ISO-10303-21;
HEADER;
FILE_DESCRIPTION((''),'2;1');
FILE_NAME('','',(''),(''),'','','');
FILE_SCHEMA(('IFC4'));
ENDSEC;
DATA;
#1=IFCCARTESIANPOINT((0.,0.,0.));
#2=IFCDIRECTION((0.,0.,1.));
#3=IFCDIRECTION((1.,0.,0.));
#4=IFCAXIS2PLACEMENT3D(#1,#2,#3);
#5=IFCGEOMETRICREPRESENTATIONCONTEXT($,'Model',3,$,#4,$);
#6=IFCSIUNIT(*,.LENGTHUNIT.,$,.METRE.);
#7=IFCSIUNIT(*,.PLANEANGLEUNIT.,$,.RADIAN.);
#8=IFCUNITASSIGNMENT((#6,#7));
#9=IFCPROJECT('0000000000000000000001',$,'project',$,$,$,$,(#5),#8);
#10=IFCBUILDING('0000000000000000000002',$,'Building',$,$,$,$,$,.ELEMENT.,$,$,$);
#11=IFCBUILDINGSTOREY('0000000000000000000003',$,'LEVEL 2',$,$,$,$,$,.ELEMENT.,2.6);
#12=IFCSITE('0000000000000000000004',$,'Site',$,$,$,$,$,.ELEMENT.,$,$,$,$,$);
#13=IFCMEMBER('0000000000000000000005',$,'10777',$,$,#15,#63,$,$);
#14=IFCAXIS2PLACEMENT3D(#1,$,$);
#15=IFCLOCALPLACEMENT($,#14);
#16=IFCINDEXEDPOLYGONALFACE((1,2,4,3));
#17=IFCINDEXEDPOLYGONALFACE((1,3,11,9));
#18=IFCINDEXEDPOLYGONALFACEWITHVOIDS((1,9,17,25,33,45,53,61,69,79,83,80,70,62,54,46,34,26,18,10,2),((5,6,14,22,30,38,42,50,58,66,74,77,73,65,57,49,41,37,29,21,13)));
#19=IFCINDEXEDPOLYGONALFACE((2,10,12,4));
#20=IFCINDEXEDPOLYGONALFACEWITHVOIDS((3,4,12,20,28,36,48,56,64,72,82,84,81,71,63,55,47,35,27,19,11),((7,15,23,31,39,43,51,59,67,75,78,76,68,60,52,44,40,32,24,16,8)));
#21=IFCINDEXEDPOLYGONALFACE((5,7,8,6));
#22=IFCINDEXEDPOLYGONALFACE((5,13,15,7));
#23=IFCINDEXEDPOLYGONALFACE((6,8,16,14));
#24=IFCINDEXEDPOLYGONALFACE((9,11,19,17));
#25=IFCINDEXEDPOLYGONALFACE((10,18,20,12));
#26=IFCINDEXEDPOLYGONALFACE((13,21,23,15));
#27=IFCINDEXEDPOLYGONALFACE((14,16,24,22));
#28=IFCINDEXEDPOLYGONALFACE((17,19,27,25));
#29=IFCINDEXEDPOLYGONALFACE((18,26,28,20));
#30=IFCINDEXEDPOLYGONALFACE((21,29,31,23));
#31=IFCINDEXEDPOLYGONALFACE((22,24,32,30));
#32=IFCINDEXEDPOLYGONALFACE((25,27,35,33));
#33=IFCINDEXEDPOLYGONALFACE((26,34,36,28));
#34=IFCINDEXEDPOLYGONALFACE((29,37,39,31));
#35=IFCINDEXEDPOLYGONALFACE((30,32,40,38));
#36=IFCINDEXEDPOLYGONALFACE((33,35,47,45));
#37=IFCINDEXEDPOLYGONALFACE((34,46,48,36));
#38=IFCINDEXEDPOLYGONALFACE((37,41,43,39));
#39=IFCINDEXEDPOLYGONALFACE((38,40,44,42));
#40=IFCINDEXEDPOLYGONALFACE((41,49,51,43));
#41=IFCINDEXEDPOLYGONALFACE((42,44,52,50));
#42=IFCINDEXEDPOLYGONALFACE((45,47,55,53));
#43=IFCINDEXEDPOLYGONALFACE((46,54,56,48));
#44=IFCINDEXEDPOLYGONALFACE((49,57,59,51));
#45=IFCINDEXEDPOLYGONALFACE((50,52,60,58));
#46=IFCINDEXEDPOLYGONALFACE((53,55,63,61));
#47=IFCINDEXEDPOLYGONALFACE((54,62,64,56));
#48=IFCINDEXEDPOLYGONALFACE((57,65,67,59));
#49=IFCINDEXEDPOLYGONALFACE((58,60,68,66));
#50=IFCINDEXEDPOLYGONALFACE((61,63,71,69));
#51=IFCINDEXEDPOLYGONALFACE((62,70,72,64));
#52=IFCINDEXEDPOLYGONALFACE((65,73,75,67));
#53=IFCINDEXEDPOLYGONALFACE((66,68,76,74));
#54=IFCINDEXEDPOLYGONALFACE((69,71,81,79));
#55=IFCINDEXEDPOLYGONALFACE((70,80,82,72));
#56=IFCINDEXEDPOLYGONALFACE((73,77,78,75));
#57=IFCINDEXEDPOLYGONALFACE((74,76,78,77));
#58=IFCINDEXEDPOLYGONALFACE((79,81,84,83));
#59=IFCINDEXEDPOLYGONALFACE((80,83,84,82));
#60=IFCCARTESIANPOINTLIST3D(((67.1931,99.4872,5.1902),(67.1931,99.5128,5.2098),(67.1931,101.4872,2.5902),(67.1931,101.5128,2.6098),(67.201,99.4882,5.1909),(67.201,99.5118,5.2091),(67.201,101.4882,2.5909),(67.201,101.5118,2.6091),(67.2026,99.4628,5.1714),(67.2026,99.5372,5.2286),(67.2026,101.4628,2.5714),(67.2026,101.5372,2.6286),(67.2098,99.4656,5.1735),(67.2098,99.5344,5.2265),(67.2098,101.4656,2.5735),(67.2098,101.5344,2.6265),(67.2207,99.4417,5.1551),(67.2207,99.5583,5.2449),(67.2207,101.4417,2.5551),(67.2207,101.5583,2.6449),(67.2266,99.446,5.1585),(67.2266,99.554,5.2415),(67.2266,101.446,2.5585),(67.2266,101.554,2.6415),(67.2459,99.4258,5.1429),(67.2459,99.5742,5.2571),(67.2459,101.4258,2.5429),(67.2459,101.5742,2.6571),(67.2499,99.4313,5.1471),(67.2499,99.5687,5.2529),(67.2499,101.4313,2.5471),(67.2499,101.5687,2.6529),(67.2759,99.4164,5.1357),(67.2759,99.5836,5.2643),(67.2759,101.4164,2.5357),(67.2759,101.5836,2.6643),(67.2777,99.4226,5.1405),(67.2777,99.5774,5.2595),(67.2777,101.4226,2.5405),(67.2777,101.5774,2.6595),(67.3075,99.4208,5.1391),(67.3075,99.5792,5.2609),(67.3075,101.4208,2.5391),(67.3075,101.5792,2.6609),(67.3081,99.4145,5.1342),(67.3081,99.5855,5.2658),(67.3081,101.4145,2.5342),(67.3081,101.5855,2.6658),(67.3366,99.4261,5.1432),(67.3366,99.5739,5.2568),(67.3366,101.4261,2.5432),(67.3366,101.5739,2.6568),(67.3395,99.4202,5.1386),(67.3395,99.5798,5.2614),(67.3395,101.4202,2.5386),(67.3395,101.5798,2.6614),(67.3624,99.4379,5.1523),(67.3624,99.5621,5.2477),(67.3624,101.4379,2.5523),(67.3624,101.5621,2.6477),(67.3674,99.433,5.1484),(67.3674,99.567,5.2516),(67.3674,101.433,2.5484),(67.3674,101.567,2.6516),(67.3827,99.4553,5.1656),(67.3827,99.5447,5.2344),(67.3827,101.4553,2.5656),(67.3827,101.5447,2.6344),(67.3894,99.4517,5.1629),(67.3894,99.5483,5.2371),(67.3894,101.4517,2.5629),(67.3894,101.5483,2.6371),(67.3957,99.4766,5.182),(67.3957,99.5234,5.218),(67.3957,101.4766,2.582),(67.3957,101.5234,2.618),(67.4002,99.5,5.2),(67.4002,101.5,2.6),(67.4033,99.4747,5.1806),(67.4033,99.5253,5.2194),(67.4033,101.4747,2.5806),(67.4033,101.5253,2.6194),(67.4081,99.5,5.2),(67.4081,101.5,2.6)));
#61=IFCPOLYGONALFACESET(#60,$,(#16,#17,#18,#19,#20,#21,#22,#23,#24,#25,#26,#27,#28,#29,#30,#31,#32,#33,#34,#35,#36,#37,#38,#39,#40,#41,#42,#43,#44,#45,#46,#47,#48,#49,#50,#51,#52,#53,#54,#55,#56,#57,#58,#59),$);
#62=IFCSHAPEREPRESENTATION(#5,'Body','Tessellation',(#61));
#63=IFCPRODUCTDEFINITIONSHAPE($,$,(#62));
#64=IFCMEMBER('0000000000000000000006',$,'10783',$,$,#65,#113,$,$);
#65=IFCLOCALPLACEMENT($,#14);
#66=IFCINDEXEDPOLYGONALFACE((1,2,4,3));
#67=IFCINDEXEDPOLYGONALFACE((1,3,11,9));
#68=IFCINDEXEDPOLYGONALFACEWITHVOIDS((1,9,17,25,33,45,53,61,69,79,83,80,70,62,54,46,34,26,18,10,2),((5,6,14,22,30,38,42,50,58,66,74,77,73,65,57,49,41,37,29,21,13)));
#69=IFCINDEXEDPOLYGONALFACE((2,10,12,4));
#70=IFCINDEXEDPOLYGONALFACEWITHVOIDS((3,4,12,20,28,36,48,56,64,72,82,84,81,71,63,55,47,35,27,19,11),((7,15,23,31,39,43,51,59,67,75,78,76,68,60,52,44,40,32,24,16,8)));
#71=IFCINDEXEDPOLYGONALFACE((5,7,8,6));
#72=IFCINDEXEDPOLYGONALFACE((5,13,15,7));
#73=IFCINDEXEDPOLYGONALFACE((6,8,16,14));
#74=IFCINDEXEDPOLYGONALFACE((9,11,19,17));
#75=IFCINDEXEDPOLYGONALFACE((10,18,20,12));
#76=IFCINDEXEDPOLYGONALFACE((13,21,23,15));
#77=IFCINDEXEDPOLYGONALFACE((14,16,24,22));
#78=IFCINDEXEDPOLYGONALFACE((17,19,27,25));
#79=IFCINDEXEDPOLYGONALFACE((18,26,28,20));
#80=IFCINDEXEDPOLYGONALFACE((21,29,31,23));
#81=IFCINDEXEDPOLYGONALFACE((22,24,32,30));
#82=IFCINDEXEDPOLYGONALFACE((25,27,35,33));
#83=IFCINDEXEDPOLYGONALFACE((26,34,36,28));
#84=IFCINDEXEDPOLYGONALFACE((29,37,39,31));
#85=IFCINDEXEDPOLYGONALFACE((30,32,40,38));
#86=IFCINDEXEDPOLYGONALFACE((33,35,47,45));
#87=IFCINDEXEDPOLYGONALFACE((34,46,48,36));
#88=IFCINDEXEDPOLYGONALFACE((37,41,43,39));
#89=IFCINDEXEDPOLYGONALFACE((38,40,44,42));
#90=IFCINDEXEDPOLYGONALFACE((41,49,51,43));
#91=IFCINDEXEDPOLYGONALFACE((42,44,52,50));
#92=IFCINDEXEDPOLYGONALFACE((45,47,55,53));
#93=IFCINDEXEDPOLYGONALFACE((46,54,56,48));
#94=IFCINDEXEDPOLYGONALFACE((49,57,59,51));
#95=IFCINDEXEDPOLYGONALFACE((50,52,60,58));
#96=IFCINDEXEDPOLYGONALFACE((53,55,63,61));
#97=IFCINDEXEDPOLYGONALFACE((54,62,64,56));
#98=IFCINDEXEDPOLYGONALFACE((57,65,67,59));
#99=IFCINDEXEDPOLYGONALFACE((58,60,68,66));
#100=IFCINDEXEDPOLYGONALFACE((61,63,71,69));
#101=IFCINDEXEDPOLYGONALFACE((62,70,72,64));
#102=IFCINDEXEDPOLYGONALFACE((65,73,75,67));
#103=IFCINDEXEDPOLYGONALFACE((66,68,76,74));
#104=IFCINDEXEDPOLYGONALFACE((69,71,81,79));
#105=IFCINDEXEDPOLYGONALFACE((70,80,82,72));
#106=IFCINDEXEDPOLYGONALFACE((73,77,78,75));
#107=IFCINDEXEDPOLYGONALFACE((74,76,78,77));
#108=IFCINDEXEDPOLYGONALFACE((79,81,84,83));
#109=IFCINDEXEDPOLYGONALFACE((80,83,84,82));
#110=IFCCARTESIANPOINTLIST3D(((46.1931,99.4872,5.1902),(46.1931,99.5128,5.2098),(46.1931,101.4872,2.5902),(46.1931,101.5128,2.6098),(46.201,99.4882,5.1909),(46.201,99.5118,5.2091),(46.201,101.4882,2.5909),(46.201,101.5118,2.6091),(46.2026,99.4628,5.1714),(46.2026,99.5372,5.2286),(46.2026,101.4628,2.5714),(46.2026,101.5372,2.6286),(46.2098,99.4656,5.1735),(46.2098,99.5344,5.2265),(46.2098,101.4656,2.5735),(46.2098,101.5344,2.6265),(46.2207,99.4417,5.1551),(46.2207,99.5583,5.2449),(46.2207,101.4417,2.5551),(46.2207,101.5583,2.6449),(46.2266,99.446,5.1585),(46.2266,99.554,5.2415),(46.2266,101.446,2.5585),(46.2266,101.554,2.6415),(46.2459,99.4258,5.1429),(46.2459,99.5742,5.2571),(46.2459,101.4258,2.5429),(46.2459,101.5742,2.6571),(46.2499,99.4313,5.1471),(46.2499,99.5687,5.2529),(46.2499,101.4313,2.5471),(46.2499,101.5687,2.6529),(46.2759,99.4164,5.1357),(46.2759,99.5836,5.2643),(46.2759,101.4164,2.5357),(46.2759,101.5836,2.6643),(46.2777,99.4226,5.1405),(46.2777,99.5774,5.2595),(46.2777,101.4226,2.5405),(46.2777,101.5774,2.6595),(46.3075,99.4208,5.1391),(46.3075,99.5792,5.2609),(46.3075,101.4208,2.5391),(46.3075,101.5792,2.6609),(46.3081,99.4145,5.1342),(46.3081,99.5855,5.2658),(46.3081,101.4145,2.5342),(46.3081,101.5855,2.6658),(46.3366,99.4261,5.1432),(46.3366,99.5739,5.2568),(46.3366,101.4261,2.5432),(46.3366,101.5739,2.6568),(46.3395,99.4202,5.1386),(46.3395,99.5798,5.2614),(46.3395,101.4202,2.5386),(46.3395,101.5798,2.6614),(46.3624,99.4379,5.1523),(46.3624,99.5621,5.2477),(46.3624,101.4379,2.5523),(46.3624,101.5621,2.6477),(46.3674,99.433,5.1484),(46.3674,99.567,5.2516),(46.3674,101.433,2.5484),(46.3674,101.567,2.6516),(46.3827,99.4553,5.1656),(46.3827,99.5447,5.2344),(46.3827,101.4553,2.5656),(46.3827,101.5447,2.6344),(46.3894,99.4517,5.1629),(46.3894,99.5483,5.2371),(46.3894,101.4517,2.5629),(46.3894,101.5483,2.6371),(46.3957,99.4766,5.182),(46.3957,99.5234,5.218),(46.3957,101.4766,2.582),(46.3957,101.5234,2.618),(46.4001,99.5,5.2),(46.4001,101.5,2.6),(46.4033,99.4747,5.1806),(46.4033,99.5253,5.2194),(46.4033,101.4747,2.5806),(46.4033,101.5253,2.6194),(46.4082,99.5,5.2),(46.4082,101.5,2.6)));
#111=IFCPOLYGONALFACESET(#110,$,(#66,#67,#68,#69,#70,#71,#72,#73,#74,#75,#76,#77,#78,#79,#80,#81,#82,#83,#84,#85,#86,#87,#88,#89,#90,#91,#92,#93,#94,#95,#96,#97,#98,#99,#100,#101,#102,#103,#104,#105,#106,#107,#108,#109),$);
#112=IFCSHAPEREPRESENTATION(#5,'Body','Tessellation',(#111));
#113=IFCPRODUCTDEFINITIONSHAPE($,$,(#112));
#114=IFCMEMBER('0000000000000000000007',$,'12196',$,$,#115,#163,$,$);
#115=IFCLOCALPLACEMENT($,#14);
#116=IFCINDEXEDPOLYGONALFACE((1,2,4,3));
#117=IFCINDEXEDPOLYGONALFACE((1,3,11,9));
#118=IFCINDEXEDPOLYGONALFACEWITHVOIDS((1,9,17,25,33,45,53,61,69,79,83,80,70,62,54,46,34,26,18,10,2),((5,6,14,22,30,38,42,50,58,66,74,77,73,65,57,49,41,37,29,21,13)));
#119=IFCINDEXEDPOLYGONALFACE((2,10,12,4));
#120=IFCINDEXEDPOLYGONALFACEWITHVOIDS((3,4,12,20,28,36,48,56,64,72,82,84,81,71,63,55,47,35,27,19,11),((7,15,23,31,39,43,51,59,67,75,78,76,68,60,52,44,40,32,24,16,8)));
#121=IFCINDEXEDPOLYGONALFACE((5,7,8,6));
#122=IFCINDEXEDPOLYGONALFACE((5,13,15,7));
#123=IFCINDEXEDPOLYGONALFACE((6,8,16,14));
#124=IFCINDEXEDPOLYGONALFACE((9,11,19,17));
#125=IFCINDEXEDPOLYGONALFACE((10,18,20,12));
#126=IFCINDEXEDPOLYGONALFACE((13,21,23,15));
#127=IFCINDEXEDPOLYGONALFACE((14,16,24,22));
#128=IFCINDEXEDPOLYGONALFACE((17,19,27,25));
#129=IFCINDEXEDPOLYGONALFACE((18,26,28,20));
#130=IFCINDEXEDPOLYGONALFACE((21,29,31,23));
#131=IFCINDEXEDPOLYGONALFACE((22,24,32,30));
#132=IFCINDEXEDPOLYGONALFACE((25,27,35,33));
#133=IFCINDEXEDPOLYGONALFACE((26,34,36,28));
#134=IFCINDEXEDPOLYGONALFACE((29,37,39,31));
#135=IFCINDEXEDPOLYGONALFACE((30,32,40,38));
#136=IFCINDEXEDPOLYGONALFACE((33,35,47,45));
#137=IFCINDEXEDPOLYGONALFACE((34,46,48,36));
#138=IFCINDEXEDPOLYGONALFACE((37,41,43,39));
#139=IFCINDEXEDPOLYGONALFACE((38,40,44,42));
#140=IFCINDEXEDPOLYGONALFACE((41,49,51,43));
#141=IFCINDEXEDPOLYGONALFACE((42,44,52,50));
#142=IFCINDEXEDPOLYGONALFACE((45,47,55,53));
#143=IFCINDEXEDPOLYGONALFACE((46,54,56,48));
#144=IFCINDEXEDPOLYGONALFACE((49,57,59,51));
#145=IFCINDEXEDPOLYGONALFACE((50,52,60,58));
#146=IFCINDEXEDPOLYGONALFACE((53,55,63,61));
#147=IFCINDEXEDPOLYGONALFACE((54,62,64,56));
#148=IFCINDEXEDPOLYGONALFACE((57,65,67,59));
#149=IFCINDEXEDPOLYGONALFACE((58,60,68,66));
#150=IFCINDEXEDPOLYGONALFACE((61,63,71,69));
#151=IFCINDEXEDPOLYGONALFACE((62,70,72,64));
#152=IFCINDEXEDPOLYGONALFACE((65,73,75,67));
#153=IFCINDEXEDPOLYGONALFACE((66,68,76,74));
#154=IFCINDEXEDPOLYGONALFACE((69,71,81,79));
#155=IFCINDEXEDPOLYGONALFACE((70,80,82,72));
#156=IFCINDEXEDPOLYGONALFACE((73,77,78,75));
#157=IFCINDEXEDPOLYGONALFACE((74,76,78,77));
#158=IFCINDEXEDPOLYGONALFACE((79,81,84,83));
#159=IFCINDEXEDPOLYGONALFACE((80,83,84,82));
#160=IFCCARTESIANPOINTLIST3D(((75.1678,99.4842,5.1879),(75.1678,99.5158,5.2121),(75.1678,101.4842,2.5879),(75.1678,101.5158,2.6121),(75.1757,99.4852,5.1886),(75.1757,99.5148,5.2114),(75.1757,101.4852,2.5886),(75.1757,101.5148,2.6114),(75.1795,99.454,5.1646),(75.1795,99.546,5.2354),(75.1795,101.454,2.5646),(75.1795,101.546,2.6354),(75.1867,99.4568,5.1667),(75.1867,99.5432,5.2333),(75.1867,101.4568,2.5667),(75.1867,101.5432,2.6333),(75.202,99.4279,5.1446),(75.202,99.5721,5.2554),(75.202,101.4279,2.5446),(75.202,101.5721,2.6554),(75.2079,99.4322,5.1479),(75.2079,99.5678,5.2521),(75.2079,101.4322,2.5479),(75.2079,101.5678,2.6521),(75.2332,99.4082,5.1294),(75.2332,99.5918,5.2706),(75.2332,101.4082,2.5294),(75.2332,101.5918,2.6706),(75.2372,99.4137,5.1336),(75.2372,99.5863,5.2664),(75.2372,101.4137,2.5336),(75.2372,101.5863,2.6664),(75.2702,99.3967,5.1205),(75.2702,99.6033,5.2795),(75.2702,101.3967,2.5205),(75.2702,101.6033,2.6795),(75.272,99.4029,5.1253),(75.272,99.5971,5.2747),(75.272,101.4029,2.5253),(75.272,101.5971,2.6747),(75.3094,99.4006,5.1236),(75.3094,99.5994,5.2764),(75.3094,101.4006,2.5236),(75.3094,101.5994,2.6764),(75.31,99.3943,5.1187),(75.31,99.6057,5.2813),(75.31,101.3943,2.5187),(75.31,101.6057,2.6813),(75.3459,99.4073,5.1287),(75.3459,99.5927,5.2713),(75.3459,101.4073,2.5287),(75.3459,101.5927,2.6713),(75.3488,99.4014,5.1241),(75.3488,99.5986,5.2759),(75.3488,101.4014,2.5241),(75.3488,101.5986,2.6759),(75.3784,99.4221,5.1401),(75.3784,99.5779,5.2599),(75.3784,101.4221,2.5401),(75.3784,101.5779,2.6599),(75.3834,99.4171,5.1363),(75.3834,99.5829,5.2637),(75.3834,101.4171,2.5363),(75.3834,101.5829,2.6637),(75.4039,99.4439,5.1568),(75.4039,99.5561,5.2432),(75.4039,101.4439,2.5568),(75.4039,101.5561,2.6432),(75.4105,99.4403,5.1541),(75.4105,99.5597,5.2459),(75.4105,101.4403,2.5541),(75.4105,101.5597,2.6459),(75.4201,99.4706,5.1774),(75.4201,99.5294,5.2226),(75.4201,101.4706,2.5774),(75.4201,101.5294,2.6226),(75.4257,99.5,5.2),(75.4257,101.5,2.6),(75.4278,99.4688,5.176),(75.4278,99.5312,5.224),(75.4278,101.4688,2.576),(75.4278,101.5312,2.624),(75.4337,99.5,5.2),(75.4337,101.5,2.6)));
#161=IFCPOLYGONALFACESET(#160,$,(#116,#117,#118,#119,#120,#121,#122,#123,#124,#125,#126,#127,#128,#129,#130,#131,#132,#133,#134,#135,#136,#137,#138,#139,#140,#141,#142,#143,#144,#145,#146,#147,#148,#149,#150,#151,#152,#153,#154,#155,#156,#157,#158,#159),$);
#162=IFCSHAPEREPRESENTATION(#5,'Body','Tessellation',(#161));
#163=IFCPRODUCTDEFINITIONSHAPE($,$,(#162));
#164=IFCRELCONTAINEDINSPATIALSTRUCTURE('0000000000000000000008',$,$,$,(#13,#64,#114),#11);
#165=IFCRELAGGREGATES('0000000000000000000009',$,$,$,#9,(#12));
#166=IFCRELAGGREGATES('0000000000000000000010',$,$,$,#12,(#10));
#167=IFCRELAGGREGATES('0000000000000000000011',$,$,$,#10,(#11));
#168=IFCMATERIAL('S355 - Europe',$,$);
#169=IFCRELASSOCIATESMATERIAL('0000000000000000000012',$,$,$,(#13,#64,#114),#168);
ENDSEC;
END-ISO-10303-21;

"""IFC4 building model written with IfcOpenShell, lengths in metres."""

from ifc_helpers import new_model, si_unit, frame, origin_with_axes, origin_2d_with_axis, place, context, project, spatial, hollow_circle, extrude, material, material_profile, profile_set, profile_usage, element, save


model = new_model("IFC4")

# Units and contexts
model_context = context("Model", 3, world=origin_with_axes())
ifc_project = project(units=[si_unit("LENGTHUNIT", "METRE"), si_unit("PLANEANGLEUNIT", "RADIAN")], contexts=[model_context])

# Site, building, storey
site = spatial("IfcSite", under=ifc_project, Name="Site", CompositionType="ELEMENT")
building = spatial("IfcBuilding", under=site, Name="Building", CompositionType="ELEMENT")
storey = spatial("IfcBuildingStorey", under=building, Name="LEVEL 2", CompositionType="ELEMENT", Elevation=2.6)

# Shared definitions
ifc_material = material(Name="S355 - Europe")

# Members
ifc_material_profile_1 = material_profile(ifc_material, hollow_circle(Radius=0.1081, WallThickness=0.008, at=origin_2d_with_axis()))
ifc_profile_set_1 = profile_set([ifc_material_profile_1])
ifc_profile_usage_1 = profile_usage(ifc_profile_set_1, cardinal=10)
member_1_placement = place(None, frame((67.3, 101.5, 2.6), z_axis=(0.0, -0.609711, 0.792624), x_axis=(1.0, 0.0, 0.0)))
element("IfcMember", 1, at=member_1_placement, inside=storey, material=ifc_profile_usage_1, Name="10777", context=model_context, shape_type="SweptSolid", body=[
    extrude(hollow_circle(Radius=0.1081, WallThickness=0.008, at=origin_2d_with_axis()), origin_with_axes(), (0.0, 0.0, 1.0), 3.2802),
])
ifc_material_profile_2 = material_profile(ifc_material, hollow_circle(Radius=0.1081, WallThickness=0.008, at=origin_2d_with_axis()))
ifc_profile_set_2 = profile_set([ifc_material_profile_2])
ifc_profile_usage_2 = profile_usage(ifc_profile_set_2, cardinal=10)
member_2_placement = place(None, frame((46.3, 101.5, 2.6), z_axis=(0.0, -0.609711, 0.792624), x_axis=(1.0, 0.0, 0.0)))
element("IfcMember", 2, at=member_2_placement, inside=storey, material=ifc_profile_usage_2, Name="10783", context=model_context, shape_type="SweptSolid", body=[
    extrude(hollow_circle(Radius=0.1081, WallThickness=0.008, at=origin_2d_with_axis()), origin_with_axes(), (0.0, 0.0, 1.0), 3.2802),
])
ifc_material_profile_3 = material_profile(ifc_material, hollow_circle(Radius=0.1337, WallThickness=0.008, at=origin_2d_with_axis()))
ifc_profile_set_3 = profile_set([ifc_material_profile_3])
ifc_profile_usage_3 = profile_usage(ifc_profile_set_3, cardinal=10)
member_3_placement = place(None, frame((75.3, 101.5, 2.6), z_axis=(0.0, -0.609711, 0.792624), x_axis=(1.0, 0.0, 0.0)))
element("IfcMember", 3, at=member_3_placement, inside=storey, material=ifc_profile_usage_3, Name="12196", context=model_context, shape_type="SweptSolid", body=[
    extrude(hollow_circle(Radius=0.1337, WallThickness=0.008, at=origin_2d_with_axis()), origin_with_axes(), (0.0, 0.0, 1.0), 3.2802),
])

save(model, "model.ifc")
